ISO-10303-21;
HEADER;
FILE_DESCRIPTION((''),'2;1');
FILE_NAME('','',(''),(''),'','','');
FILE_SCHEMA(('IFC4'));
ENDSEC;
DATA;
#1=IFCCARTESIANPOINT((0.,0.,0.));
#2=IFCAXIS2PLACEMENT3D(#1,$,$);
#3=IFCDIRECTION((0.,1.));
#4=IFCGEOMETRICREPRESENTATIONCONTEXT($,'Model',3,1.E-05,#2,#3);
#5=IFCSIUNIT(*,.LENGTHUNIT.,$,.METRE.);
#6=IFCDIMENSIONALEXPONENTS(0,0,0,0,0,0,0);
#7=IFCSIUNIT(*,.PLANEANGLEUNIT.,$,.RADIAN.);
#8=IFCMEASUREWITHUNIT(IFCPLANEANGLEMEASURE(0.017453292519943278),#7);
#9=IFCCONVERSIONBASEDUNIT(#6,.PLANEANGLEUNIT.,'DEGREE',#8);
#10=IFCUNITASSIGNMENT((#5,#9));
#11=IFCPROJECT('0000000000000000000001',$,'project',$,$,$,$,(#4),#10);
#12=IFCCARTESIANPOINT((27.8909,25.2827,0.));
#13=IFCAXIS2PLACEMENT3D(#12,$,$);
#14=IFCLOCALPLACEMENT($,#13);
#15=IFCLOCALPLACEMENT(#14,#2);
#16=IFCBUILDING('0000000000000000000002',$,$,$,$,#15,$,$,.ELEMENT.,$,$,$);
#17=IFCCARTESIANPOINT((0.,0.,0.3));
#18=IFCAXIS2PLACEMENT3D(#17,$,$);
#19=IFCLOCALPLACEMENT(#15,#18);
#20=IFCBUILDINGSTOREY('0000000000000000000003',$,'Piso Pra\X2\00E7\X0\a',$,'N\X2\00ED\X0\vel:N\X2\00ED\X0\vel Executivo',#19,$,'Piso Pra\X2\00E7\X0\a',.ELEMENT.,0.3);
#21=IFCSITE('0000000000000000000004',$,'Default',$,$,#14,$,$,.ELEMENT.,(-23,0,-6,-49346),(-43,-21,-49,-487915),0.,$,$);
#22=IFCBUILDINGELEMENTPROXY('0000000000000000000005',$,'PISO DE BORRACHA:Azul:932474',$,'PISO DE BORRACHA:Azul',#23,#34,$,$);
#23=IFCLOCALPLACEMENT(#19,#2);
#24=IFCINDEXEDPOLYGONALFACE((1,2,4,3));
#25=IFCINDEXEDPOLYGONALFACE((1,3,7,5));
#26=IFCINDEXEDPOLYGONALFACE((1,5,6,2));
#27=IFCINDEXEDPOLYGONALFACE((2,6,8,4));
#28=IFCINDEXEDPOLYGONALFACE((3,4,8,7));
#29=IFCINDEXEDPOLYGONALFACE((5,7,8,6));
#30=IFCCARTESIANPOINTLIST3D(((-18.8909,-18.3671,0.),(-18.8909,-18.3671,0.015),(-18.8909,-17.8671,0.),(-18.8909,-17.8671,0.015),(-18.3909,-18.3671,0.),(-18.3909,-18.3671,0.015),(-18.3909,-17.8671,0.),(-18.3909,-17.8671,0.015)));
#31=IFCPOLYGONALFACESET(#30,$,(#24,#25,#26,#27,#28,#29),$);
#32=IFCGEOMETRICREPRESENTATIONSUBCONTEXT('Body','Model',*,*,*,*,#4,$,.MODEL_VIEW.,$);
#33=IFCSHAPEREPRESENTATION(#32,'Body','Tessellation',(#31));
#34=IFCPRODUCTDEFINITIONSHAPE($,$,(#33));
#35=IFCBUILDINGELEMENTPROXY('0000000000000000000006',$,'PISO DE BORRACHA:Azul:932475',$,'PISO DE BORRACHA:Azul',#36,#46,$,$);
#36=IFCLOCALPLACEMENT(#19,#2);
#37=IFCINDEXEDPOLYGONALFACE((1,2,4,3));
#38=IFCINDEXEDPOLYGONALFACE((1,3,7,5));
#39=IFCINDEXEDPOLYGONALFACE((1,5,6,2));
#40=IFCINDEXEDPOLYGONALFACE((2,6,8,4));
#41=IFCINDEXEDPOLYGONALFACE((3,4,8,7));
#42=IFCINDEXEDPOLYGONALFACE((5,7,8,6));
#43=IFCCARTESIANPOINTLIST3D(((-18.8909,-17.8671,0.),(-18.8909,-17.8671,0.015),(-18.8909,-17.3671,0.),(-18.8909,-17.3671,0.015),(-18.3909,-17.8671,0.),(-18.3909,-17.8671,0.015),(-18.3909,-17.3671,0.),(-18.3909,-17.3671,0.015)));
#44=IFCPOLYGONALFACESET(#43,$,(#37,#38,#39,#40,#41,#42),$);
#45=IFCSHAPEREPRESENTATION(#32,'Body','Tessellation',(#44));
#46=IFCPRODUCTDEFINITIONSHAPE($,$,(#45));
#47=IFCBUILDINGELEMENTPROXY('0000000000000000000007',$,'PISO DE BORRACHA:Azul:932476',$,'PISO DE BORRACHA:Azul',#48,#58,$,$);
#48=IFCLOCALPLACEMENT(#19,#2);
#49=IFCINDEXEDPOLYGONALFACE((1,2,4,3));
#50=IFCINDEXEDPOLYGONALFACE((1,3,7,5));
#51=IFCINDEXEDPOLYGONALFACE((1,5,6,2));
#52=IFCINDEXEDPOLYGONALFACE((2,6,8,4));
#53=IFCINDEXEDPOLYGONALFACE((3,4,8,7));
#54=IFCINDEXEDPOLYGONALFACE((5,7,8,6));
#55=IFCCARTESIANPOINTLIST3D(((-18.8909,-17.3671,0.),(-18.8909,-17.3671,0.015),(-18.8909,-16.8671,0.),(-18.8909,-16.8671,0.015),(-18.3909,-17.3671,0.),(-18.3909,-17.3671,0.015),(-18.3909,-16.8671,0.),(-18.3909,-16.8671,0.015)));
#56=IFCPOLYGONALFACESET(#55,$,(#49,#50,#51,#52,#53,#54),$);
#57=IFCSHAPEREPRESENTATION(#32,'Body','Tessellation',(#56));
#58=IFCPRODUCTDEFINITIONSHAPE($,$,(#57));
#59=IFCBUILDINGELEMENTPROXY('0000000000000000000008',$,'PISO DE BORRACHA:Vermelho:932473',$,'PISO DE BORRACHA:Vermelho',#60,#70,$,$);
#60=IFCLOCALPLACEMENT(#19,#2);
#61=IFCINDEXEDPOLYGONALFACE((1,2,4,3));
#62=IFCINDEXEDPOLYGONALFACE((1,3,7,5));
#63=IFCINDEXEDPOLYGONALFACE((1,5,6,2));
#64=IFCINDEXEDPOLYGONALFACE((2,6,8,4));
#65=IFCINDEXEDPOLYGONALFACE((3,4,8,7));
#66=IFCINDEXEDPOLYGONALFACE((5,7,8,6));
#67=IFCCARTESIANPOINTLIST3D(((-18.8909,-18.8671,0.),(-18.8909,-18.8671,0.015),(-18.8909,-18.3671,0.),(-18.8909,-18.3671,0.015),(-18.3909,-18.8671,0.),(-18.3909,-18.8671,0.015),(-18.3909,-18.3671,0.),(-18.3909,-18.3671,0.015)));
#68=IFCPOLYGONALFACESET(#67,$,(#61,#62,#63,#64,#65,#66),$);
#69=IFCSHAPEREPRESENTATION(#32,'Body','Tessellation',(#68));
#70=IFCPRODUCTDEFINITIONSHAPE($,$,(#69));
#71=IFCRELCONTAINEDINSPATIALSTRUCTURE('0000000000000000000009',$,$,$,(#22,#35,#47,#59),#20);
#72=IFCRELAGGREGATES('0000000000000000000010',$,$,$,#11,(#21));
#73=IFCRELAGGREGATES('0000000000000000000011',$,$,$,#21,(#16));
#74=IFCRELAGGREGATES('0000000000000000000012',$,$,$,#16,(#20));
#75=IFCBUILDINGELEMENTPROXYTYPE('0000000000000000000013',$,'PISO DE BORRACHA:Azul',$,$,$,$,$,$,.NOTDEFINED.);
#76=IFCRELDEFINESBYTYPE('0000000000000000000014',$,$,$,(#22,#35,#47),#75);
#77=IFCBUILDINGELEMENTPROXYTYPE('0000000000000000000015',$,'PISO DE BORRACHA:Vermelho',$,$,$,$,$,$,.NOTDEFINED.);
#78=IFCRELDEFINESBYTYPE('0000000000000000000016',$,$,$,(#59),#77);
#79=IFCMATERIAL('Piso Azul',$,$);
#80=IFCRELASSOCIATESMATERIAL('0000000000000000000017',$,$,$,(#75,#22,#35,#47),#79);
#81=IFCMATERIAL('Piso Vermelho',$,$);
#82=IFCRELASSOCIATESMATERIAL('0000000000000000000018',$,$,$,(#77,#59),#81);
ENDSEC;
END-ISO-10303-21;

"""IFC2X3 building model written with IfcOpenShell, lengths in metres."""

from ifc_helpers import new_model, entity, si_unit, converted_unit, direction, frame, origin, origin_2d_with_axis, place, context, subcontext, project, spatial, rectangle, extrude, source, transform, mapped, material, type_object, type_shapes, element, save


model = new_model("IFC2X3")

# Units and contexts
model_context = context("Model", 3, precision=1e-05, world=origin(), true_north=direction((0.0, 1.0)))
body_context = subcontext(model_context, "Body", "Model", "MODEL_VIEW")
ifc_project = project(units=[si_unit("LENGTHUNIT", "METRE"), converted_unit("PLANEANGLEUNIT", "DEGREE", entity("IfcPlaneAngleMeasure", 0.017453292519943278), si_unit("PLANEANGLEUNIT", "RADIAN"), dimensions=[0, 0, 0, 0, 0, 0, 0])], contexts=[model_context])

# Site, building, storey
site_placement = place(None, frame((27.8909, 25.2827, 0.0)))
site = spatial("IfcSite", under=ifc_project, at=site_placement, Name="Default", CompositionType="ELEMENT", RefLatitude=(-23, 0, -6, -49346), RefLongitude=(-43, -21, -49, -487915), RefElevation=0.0)
building_placement = place(site_placement, origin())
building = spatial("IfcBuilding", under=site, at=building_placement, CompositionType="ELEMENT")
storey_placement = place(building_placement, frame((0.0, 0.0, 0.3)))
storey = spatial("IfcBuildingStorey", under=building, at=storey_placement, Name="Piso Praça", ObjectType="Nível:Nível Executivo", LongName="Piso Praça", CompositionType="ELEMENT", Elevation=0.3)

# Building element proxies
ifc_material_1 = material(Name="Piso Azul")
building_element_proxy_type_1 = type_object("IfcBuildingElementProxyType", Name="PISO DE BORRACHA:Azul", PredefinedType="NOTDEFINED", material=ifc_material_1)
shared_shape_1 = source(origin(), body_context, "Body", "SweptSolid", [
    extrude(rectangle(XDim=0.5, YDim=0.5, at=origin_2d_with_axis()), frame((0.25, 0.25, 0.0), z_axis=(0.0, 0.0, 1.0), x_axis=(-1.0, 0.0, 0.0)), (0.0, 0.0, 1.0), 0.015),
])
type_shapes(building_element_proxy_type_1, [shared_shape_1])
for number, where, z_axis, x_axis, name in (
    (1, (-18.8909, -17.8671, 0.0), (0.0, 0.0, 1.0), (0.0, -1.0, 0.0), "PISO DE BORRACHA:Azul:932474"),
    (2, (-18.8909, -17.3671, 0.0), (0.0, 0.0, 1.0), (0.0, -1.0, 0.0), "PISO DE BORRACHA:Azul:932475"),
    (3, (-18.8909, -16.8671, 0.0), (0.0, 0.0, 1.0), (0.0, -1.0, 0.0), "PISO DE BORRACHA:Azul:932476"),
):
    element("IfcBuildingElementProxy", number, at=place(storey_placement, frame(where, z_axis=z_axis, x_axis=x_axis)), inside=storey, type_object=building_element_proxy_type_1, material=ifc_material_1, Name=name, ObjectType="PISO DE BORRACHA:Azul", context=body_context, shape_type="MappedRepresentation", body=[
        mapped(shared_shape_1, transform((0.0, 0.0, 0.0), scale=1.0)),
    ])
ifc_material_2 = material(Name="Piso Vermelho")
building_element_proxy_type_2 = type_object("IfcBuildingElementProxyType", Name="PISO DE BORRACHA:Vermelho", PredefinedType="NOTDEFINED", material=ifc_material_2)
shared_shape_2 = source(origin(), body_context, "Body", "SweptSolid", [
    extrude(rectangle(XDim=0.5, YDim=0.5, at=origin_2d_with_axis()), frame((0.25, 0.25, 0.0), z_axis=(0.0, 0.0, 1.0), x_axis=(-1.0, 0.0, 0.0)), (0.0, 0.0, 1.0), 0.015),
])
type_shapes(building_element_proxy_type_2, [shared_shape_2])
proxy_placement = place(storey_placement, frame((-18.8909, -18.3671, 0.0), z_axis=(0.0, 0.0, 1.0), x_axis=(0.0, -1.0, 0.0)))
element("IfcBuildingElementProxy", 4, at=proxy_placement, inside=storey, type_object=building_element_proxy_type_2, material=ifc_material_2, Name="PISO DE BORRACHA:Vermelho:932473", ObjectType="PISO DE BORRACHA:Vermelho", context=body_context, shape_type="MappedRepresentation", body=[
    mapped(shared_shape_2, transform((0.0, 0.0, 0.0), scale=1.0)),
])

save(model, "model.ifc")
